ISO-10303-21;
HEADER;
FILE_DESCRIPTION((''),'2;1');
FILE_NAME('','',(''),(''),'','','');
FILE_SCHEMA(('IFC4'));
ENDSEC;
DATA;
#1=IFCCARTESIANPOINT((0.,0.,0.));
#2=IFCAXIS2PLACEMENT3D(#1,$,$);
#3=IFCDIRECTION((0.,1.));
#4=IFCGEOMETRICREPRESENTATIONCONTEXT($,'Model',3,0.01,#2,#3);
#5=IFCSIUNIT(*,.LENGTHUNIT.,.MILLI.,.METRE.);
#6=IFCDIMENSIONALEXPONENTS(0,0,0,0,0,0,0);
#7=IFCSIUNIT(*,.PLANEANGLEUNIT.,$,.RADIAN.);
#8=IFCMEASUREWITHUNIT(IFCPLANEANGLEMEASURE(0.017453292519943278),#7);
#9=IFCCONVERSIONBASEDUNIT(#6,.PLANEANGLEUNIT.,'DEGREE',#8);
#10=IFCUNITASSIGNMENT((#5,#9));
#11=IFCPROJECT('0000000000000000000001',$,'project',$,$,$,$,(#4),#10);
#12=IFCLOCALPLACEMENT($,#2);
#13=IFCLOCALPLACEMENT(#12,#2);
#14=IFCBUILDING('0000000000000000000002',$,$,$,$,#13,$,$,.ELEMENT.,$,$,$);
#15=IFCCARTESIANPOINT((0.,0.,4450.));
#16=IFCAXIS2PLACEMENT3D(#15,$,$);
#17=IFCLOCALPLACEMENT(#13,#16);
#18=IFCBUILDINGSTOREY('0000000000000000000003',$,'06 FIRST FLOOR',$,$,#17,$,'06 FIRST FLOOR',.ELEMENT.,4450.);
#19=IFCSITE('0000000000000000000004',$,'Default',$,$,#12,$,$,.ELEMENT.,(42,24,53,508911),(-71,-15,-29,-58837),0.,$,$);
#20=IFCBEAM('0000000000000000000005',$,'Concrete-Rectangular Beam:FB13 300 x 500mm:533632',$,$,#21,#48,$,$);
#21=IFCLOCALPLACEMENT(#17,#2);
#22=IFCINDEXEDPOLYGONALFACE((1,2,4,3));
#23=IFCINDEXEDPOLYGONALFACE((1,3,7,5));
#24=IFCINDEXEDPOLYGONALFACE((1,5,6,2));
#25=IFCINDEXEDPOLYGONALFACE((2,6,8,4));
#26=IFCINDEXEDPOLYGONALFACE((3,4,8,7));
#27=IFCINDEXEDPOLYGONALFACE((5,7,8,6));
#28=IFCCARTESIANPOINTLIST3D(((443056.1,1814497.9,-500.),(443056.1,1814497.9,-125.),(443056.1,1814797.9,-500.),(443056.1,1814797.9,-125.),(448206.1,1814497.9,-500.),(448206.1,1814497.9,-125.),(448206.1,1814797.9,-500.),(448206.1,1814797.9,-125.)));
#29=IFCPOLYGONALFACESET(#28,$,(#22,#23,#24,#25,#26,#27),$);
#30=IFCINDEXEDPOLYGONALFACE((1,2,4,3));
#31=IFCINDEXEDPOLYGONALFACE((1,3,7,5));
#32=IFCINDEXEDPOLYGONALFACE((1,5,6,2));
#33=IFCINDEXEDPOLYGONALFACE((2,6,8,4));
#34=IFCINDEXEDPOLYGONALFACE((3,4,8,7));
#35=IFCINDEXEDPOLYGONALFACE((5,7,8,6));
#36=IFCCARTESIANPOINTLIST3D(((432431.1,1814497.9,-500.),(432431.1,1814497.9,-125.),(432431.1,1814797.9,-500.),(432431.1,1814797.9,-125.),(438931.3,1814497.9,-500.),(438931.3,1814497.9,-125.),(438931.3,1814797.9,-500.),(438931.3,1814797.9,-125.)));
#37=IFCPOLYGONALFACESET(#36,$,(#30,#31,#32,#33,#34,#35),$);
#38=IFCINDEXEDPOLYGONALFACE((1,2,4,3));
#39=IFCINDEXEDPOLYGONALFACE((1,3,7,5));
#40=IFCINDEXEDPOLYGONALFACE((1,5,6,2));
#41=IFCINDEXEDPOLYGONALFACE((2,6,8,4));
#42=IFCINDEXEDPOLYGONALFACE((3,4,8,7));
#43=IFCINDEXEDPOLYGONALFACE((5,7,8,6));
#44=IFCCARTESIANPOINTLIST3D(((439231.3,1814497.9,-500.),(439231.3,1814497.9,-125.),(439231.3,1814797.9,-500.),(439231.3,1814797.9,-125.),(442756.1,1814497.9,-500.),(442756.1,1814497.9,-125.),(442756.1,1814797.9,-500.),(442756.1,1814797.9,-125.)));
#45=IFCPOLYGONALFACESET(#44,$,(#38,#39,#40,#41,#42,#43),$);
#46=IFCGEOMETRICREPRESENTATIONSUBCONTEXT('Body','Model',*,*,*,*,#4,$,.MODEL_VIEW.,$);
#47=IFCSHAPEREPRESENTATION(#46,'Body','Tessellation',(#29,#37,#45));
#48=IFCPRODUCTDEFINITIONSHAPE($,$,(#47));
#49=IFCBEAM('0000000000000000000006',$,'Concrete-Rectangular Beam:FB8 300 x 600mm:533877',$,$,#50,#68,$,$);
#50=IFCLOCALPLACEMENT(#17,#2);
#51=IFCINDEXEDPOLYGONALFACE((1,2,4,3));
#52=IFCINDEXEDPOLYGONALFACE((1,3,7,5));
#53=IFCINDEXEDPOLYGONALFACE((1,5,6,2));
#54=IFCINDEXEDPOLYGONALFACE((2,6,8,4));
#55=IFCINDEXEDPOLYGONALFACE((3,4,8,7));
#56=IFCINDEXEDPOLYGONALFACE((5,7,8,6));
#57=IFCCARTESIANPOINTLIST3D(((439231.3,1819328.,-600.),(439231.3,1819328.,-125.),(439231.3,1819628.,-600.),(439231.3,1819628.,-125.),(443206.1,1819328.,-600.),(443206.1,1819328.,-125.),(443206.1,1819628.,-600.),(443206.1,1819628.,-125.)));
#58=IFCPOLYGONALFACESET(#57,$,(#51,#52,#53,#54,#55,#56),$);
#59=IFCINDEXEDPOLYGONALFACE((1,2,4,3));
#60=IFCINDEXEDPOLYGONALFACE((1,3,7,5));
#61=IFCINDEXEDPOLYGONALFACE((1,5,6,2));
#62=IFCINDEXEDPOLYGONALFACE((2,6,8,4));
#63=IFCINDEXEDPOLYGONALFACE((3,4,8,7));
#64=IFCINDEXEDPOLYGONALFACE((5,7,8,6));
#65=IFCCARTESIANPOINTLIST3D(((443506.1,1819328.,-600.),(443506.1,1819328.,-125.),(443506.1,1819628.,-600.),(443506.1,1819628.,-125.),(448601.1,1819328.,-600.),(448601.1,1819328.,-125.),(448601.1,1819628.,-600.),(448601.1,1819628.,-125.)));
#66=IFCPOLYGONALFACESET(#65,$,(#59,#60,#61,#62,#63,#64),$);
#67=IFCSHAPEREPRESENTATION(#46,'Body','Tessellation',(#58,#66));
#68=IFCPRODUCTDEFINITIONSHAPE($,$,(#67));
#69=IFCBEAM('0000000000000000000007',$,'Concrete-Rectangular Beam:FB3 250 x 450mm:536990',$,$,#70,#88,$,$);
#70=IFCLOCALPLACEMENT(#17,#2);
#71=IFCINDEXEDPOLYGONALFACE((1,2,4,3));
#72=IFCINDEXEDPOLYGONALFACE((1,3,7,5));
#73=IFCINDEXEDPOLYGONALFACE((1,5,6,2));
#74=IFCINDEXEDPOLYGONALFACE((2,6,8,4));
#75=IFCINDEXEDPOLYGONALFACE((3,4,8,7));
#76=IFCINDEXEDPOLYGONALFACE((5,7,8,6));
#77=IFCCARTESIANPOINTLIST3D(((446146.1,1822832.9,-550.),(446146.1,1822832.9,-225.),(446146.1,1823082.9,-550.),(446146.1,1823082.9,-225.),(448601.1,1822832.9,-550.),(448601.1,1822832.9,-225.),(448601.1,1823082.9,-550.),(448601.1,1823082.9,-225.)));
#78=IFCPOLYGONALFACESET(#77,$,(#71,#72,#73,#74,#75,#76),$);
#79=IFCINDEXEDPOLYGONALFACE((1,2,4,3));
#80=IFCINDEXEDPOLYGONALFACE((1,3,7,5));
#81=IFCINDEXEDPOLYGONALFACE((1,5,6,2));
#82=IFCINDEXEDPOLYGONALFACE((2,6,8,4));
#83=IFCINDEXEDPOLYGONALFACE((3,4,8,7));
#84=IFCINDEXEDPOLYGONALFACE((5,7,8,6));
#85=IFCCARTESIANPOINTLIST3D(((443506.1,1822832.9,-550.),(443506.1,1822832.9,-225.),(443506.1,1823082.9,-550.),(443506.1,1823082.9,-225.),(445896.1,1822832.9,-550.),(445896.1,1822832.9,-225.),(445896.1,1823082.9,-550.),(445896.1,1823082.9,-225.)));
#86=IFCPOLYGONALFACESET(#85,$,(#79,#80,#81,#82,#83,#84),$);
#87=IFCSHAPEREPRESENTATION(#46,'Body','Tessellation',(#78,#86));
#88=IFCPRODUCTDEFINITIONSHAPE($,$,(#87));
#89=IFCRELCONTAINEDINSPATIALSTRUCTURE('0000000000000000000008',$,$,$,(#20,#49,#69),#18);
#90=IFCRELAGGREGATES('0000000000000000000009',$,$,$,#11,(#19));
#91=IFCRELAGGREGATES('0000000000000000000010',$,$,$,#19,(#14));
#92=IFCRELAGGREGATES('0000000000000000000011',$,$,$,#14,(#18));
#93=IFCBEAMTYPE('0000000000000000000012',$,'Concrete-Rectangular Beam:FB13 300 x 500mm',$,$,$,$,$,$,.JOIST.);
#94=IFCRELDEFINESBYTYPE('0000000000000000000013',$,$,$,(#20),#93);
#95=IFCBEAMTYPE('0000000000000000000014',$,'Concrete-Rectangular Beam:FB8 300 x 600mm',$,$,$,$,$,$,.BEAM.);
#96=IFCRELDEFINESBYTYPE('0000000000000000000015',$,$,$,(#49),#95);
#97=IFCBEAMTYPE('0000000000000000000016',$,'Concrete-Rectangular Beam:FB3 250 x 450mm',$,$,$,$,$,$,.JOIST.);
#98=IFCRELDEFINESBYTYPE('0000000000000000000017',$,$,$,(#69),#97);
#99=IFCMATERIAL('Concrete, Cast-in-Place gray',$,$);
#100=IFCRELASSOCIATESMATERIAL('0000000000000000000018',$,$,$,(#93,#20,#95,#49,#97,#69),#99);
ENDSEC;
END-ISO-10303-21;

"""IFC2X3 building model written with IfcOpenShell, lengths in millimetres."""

from ifc_helpers import new_model, entity, si_unit, converted_unit, direction, frame, frame_2d, origin, origin_2d_with_axis, place, context, subcontext, project, spatial, rectangle, extrude, source, transform, mapped, material, type_object, type_shapes, element, save


model = new_model("IFC2X3")

# Units and contexts
model_context = context("Model", 3, precision=0.01, world=origin(), true_north=direction((0.0, 1.0)))
body_context = subcontext(model_context, "Body", "Model", "MODEL_VIEW")
ifc_project = project(units=[si_unit("LENGTHUNIT", "METRE", prefix="MILLI"), converted_unit("PLANEANGLEUNIT", "DEGREE", entity("IfcPlaneAngleMeasure", 0.017453292519943278), si_unit("PLANEANGLEUNIT", "RADIAN"), dimensions=[0, 0, 0, 0, 0, 0, 0])], contexts=[model_context])

# Site, building, storey
site_placement = place(None, origin())
site = spatial("IfcSite", under=ifc_project, at=site_placement, Name="Default", CompositionType="ELEMENT", RefLatitude=(42, 24, 53, 508911), RefLongitude=(-71, -15, -29, -58837), RefElevation=0.0)
building_placement = place(site_placement, origin())
building = spatial("IfcBuilding", under=site, at=building_placement, CompositionType="ELEMENT")
storey_placement = place(building_placement, frame((0.0, 0.0, 4450.0)))
storey = spatial("IfcBuildingStorey", under=building, at=storey_placement, Name="06 FIRST FLOOR", LongName="06 FIRST FLOOR", CompositionType="ELEMENT", Elevation=4450.0)

# Shared definitions
ifc_material_1 = material(Name="Concrete, Cast-in-Place gray")

# Beams
beam_type_1 = type_object("IfcBeamType", Name="Concrete-Rectangular Beam:FB13 300 x 500mm", PredefinedType="JOIST", material=ifc_material_1)
shared_shape_1 = source(origin(), body_context, "Body", "SweptSolid", [
    extrude(rectangle(XDim=375.0, YDim=300.0, at=frame_2d((0.0, 0.0), x_axis=(1.0, 0.0))), frame((443056.1, 1814647.9, 4137.5), z_axis=(1.0, 0.0, 0.0), x_axis=(0.0, 0.0, -1.0)), (0.0, 0.0, 1.0), 5150.0),
    extrude(rectangle(XDim=375.0, YDim=300.0, at=frame_2d((0.0, 0.0), x_axis=(1.0, 0.0))), frame((432431.1, 1814647.9, 4137.5), z_axis=(1.0, 0.0, 0.0), x_axis=(0.0, 0.0, -1.0)), (0.0, 0.0, 1.0), 6500.1),
    extrude(rectangle(XDim=375.0, YDim=300.0, at=frame_2d((0.0, 0.0), x_axis=(1.0, 0.0))), frame((439231.3, 1814647.9, 4137.5), z_axis=(1.0, 0.0, 0.0), x_axis=(0.0, 0.0, -1.0)), (0.0, 0.0, 1.0), 3524.9),
])
type_shapes(beam_type_1, [shared_shape_1])
beam_1_placement = place(storey_placement, frame((0.0, 0.0, -4450.0)))
element("IfcBeam", 1, at=beam_1_placement, inside=storey, type_object=beam_type_1, material=ifc_material_1, Name="Concrete-Rectangular Beam:FB13 300 x 500mm:533632", context=body_context, shape_type="MappedRepresentation", body=[
    mapped(shared_shape_1, transform((0.0, 0.0, 0.0), scale=1.0)),
])
beam_type_2 = type_object("IfcBeamType", Name="Concrete-Rectangular Beam:FB8 300 x 600mm", PredefinedType="BEAM", material=ifc_material_1)
shared_shape_2 = source(origin(), body_context, "Body", "SweptSolid", [
    extrude(rectangle(XDim=475.0, YDim=300.0, at=origin_2d_with_axis()), frame((439231.3, 1819478.0, 4087.5), z_axis=(1.0, 0.0, 0.0), x_axis=(0.0, 0.0, -1.0)), (0.0, 0.0, 1.0), 3974.8),
    extrude(rectangle(XDim=475.0, YDim=300.0, at=origin_2d_with_axis()), frame((443506.1, 1819478.0, 4087.5), z_axis=(1.0, 0.0, 0.0), x_axis=(0.0, 0.0, -1.0)), (0.0, 0.0, 1.0), 5095.0),
])
type_shapes(beam_type_2, [shared_shape_2])
beam_2_placement = place(storey_placement, frame((0.0, 0.0, -4450.0)))
element("IfcBeam", 2, at=beam_2_placement, inside=storey, type_object=beam_type_2, material=ifc_material_1, Name="Concrete-Rectangular Beam:FB8 300 x 600mm:533877", context=body_context, shape_type="MappedRepresentation", body=[
    mapped(shared_shape_2, transform((0.0, 0.0, 0.0), scale=1.0)),
])
beam_type_3 = type_object("IfcBeamType", Name="Concrete-Rectangular Beam:FB3 250 x 450mm", PredefinedType="JOIST", material=ifc_material_1)
shared_shape_3 = source(origin(), body_context, "Body", "SweptSolid", [
    extrude(rectangle(XDim=325.0, YDim=250.0, at=frame_2d((0.0, 0.0), x_axis=(1.0, 0.0))), frame((446146.1, 1822957.9, 4062.5), z_axis=(1.0, 0.0, 0.0), x_axis=(0.0, 0.0, -1.0)), (0.0, 0.0, 1.0), 2455.0),
    extrude(rectangle(XDim=325.0, YDim=250.0, at=frame_2d((0.0, 0.0), x_axis=(1.0, 0.0))), frame((443506.1, 1822957.9, 4062.5), z_axis=(1.0, 0.0, 0.0), x_axis=(0.0, 0.0, -1.0)), (0.0, 0.0, 1.0), 2390.0),
])
type_shapes(beam_type_3, [shared_shape_3])
beam_3_placement = place(storey_placement, frame((0.0, 0.0, -4450.0)))
element("IfcBeam", 3, at=beam_3_placement, inside=storey, type_object=beam_type_3, material=ifc_material_1, Name="Concrete-Rectangular Beam:FB3 250 x 450mm:536990", context=body_context, shape_type="MappedRepresentation", body=[
    mapped(shared_shape_3, transform((0.0, 0.0, 0.0), scale=1.0)),
])

save(model, "model.ifc")
